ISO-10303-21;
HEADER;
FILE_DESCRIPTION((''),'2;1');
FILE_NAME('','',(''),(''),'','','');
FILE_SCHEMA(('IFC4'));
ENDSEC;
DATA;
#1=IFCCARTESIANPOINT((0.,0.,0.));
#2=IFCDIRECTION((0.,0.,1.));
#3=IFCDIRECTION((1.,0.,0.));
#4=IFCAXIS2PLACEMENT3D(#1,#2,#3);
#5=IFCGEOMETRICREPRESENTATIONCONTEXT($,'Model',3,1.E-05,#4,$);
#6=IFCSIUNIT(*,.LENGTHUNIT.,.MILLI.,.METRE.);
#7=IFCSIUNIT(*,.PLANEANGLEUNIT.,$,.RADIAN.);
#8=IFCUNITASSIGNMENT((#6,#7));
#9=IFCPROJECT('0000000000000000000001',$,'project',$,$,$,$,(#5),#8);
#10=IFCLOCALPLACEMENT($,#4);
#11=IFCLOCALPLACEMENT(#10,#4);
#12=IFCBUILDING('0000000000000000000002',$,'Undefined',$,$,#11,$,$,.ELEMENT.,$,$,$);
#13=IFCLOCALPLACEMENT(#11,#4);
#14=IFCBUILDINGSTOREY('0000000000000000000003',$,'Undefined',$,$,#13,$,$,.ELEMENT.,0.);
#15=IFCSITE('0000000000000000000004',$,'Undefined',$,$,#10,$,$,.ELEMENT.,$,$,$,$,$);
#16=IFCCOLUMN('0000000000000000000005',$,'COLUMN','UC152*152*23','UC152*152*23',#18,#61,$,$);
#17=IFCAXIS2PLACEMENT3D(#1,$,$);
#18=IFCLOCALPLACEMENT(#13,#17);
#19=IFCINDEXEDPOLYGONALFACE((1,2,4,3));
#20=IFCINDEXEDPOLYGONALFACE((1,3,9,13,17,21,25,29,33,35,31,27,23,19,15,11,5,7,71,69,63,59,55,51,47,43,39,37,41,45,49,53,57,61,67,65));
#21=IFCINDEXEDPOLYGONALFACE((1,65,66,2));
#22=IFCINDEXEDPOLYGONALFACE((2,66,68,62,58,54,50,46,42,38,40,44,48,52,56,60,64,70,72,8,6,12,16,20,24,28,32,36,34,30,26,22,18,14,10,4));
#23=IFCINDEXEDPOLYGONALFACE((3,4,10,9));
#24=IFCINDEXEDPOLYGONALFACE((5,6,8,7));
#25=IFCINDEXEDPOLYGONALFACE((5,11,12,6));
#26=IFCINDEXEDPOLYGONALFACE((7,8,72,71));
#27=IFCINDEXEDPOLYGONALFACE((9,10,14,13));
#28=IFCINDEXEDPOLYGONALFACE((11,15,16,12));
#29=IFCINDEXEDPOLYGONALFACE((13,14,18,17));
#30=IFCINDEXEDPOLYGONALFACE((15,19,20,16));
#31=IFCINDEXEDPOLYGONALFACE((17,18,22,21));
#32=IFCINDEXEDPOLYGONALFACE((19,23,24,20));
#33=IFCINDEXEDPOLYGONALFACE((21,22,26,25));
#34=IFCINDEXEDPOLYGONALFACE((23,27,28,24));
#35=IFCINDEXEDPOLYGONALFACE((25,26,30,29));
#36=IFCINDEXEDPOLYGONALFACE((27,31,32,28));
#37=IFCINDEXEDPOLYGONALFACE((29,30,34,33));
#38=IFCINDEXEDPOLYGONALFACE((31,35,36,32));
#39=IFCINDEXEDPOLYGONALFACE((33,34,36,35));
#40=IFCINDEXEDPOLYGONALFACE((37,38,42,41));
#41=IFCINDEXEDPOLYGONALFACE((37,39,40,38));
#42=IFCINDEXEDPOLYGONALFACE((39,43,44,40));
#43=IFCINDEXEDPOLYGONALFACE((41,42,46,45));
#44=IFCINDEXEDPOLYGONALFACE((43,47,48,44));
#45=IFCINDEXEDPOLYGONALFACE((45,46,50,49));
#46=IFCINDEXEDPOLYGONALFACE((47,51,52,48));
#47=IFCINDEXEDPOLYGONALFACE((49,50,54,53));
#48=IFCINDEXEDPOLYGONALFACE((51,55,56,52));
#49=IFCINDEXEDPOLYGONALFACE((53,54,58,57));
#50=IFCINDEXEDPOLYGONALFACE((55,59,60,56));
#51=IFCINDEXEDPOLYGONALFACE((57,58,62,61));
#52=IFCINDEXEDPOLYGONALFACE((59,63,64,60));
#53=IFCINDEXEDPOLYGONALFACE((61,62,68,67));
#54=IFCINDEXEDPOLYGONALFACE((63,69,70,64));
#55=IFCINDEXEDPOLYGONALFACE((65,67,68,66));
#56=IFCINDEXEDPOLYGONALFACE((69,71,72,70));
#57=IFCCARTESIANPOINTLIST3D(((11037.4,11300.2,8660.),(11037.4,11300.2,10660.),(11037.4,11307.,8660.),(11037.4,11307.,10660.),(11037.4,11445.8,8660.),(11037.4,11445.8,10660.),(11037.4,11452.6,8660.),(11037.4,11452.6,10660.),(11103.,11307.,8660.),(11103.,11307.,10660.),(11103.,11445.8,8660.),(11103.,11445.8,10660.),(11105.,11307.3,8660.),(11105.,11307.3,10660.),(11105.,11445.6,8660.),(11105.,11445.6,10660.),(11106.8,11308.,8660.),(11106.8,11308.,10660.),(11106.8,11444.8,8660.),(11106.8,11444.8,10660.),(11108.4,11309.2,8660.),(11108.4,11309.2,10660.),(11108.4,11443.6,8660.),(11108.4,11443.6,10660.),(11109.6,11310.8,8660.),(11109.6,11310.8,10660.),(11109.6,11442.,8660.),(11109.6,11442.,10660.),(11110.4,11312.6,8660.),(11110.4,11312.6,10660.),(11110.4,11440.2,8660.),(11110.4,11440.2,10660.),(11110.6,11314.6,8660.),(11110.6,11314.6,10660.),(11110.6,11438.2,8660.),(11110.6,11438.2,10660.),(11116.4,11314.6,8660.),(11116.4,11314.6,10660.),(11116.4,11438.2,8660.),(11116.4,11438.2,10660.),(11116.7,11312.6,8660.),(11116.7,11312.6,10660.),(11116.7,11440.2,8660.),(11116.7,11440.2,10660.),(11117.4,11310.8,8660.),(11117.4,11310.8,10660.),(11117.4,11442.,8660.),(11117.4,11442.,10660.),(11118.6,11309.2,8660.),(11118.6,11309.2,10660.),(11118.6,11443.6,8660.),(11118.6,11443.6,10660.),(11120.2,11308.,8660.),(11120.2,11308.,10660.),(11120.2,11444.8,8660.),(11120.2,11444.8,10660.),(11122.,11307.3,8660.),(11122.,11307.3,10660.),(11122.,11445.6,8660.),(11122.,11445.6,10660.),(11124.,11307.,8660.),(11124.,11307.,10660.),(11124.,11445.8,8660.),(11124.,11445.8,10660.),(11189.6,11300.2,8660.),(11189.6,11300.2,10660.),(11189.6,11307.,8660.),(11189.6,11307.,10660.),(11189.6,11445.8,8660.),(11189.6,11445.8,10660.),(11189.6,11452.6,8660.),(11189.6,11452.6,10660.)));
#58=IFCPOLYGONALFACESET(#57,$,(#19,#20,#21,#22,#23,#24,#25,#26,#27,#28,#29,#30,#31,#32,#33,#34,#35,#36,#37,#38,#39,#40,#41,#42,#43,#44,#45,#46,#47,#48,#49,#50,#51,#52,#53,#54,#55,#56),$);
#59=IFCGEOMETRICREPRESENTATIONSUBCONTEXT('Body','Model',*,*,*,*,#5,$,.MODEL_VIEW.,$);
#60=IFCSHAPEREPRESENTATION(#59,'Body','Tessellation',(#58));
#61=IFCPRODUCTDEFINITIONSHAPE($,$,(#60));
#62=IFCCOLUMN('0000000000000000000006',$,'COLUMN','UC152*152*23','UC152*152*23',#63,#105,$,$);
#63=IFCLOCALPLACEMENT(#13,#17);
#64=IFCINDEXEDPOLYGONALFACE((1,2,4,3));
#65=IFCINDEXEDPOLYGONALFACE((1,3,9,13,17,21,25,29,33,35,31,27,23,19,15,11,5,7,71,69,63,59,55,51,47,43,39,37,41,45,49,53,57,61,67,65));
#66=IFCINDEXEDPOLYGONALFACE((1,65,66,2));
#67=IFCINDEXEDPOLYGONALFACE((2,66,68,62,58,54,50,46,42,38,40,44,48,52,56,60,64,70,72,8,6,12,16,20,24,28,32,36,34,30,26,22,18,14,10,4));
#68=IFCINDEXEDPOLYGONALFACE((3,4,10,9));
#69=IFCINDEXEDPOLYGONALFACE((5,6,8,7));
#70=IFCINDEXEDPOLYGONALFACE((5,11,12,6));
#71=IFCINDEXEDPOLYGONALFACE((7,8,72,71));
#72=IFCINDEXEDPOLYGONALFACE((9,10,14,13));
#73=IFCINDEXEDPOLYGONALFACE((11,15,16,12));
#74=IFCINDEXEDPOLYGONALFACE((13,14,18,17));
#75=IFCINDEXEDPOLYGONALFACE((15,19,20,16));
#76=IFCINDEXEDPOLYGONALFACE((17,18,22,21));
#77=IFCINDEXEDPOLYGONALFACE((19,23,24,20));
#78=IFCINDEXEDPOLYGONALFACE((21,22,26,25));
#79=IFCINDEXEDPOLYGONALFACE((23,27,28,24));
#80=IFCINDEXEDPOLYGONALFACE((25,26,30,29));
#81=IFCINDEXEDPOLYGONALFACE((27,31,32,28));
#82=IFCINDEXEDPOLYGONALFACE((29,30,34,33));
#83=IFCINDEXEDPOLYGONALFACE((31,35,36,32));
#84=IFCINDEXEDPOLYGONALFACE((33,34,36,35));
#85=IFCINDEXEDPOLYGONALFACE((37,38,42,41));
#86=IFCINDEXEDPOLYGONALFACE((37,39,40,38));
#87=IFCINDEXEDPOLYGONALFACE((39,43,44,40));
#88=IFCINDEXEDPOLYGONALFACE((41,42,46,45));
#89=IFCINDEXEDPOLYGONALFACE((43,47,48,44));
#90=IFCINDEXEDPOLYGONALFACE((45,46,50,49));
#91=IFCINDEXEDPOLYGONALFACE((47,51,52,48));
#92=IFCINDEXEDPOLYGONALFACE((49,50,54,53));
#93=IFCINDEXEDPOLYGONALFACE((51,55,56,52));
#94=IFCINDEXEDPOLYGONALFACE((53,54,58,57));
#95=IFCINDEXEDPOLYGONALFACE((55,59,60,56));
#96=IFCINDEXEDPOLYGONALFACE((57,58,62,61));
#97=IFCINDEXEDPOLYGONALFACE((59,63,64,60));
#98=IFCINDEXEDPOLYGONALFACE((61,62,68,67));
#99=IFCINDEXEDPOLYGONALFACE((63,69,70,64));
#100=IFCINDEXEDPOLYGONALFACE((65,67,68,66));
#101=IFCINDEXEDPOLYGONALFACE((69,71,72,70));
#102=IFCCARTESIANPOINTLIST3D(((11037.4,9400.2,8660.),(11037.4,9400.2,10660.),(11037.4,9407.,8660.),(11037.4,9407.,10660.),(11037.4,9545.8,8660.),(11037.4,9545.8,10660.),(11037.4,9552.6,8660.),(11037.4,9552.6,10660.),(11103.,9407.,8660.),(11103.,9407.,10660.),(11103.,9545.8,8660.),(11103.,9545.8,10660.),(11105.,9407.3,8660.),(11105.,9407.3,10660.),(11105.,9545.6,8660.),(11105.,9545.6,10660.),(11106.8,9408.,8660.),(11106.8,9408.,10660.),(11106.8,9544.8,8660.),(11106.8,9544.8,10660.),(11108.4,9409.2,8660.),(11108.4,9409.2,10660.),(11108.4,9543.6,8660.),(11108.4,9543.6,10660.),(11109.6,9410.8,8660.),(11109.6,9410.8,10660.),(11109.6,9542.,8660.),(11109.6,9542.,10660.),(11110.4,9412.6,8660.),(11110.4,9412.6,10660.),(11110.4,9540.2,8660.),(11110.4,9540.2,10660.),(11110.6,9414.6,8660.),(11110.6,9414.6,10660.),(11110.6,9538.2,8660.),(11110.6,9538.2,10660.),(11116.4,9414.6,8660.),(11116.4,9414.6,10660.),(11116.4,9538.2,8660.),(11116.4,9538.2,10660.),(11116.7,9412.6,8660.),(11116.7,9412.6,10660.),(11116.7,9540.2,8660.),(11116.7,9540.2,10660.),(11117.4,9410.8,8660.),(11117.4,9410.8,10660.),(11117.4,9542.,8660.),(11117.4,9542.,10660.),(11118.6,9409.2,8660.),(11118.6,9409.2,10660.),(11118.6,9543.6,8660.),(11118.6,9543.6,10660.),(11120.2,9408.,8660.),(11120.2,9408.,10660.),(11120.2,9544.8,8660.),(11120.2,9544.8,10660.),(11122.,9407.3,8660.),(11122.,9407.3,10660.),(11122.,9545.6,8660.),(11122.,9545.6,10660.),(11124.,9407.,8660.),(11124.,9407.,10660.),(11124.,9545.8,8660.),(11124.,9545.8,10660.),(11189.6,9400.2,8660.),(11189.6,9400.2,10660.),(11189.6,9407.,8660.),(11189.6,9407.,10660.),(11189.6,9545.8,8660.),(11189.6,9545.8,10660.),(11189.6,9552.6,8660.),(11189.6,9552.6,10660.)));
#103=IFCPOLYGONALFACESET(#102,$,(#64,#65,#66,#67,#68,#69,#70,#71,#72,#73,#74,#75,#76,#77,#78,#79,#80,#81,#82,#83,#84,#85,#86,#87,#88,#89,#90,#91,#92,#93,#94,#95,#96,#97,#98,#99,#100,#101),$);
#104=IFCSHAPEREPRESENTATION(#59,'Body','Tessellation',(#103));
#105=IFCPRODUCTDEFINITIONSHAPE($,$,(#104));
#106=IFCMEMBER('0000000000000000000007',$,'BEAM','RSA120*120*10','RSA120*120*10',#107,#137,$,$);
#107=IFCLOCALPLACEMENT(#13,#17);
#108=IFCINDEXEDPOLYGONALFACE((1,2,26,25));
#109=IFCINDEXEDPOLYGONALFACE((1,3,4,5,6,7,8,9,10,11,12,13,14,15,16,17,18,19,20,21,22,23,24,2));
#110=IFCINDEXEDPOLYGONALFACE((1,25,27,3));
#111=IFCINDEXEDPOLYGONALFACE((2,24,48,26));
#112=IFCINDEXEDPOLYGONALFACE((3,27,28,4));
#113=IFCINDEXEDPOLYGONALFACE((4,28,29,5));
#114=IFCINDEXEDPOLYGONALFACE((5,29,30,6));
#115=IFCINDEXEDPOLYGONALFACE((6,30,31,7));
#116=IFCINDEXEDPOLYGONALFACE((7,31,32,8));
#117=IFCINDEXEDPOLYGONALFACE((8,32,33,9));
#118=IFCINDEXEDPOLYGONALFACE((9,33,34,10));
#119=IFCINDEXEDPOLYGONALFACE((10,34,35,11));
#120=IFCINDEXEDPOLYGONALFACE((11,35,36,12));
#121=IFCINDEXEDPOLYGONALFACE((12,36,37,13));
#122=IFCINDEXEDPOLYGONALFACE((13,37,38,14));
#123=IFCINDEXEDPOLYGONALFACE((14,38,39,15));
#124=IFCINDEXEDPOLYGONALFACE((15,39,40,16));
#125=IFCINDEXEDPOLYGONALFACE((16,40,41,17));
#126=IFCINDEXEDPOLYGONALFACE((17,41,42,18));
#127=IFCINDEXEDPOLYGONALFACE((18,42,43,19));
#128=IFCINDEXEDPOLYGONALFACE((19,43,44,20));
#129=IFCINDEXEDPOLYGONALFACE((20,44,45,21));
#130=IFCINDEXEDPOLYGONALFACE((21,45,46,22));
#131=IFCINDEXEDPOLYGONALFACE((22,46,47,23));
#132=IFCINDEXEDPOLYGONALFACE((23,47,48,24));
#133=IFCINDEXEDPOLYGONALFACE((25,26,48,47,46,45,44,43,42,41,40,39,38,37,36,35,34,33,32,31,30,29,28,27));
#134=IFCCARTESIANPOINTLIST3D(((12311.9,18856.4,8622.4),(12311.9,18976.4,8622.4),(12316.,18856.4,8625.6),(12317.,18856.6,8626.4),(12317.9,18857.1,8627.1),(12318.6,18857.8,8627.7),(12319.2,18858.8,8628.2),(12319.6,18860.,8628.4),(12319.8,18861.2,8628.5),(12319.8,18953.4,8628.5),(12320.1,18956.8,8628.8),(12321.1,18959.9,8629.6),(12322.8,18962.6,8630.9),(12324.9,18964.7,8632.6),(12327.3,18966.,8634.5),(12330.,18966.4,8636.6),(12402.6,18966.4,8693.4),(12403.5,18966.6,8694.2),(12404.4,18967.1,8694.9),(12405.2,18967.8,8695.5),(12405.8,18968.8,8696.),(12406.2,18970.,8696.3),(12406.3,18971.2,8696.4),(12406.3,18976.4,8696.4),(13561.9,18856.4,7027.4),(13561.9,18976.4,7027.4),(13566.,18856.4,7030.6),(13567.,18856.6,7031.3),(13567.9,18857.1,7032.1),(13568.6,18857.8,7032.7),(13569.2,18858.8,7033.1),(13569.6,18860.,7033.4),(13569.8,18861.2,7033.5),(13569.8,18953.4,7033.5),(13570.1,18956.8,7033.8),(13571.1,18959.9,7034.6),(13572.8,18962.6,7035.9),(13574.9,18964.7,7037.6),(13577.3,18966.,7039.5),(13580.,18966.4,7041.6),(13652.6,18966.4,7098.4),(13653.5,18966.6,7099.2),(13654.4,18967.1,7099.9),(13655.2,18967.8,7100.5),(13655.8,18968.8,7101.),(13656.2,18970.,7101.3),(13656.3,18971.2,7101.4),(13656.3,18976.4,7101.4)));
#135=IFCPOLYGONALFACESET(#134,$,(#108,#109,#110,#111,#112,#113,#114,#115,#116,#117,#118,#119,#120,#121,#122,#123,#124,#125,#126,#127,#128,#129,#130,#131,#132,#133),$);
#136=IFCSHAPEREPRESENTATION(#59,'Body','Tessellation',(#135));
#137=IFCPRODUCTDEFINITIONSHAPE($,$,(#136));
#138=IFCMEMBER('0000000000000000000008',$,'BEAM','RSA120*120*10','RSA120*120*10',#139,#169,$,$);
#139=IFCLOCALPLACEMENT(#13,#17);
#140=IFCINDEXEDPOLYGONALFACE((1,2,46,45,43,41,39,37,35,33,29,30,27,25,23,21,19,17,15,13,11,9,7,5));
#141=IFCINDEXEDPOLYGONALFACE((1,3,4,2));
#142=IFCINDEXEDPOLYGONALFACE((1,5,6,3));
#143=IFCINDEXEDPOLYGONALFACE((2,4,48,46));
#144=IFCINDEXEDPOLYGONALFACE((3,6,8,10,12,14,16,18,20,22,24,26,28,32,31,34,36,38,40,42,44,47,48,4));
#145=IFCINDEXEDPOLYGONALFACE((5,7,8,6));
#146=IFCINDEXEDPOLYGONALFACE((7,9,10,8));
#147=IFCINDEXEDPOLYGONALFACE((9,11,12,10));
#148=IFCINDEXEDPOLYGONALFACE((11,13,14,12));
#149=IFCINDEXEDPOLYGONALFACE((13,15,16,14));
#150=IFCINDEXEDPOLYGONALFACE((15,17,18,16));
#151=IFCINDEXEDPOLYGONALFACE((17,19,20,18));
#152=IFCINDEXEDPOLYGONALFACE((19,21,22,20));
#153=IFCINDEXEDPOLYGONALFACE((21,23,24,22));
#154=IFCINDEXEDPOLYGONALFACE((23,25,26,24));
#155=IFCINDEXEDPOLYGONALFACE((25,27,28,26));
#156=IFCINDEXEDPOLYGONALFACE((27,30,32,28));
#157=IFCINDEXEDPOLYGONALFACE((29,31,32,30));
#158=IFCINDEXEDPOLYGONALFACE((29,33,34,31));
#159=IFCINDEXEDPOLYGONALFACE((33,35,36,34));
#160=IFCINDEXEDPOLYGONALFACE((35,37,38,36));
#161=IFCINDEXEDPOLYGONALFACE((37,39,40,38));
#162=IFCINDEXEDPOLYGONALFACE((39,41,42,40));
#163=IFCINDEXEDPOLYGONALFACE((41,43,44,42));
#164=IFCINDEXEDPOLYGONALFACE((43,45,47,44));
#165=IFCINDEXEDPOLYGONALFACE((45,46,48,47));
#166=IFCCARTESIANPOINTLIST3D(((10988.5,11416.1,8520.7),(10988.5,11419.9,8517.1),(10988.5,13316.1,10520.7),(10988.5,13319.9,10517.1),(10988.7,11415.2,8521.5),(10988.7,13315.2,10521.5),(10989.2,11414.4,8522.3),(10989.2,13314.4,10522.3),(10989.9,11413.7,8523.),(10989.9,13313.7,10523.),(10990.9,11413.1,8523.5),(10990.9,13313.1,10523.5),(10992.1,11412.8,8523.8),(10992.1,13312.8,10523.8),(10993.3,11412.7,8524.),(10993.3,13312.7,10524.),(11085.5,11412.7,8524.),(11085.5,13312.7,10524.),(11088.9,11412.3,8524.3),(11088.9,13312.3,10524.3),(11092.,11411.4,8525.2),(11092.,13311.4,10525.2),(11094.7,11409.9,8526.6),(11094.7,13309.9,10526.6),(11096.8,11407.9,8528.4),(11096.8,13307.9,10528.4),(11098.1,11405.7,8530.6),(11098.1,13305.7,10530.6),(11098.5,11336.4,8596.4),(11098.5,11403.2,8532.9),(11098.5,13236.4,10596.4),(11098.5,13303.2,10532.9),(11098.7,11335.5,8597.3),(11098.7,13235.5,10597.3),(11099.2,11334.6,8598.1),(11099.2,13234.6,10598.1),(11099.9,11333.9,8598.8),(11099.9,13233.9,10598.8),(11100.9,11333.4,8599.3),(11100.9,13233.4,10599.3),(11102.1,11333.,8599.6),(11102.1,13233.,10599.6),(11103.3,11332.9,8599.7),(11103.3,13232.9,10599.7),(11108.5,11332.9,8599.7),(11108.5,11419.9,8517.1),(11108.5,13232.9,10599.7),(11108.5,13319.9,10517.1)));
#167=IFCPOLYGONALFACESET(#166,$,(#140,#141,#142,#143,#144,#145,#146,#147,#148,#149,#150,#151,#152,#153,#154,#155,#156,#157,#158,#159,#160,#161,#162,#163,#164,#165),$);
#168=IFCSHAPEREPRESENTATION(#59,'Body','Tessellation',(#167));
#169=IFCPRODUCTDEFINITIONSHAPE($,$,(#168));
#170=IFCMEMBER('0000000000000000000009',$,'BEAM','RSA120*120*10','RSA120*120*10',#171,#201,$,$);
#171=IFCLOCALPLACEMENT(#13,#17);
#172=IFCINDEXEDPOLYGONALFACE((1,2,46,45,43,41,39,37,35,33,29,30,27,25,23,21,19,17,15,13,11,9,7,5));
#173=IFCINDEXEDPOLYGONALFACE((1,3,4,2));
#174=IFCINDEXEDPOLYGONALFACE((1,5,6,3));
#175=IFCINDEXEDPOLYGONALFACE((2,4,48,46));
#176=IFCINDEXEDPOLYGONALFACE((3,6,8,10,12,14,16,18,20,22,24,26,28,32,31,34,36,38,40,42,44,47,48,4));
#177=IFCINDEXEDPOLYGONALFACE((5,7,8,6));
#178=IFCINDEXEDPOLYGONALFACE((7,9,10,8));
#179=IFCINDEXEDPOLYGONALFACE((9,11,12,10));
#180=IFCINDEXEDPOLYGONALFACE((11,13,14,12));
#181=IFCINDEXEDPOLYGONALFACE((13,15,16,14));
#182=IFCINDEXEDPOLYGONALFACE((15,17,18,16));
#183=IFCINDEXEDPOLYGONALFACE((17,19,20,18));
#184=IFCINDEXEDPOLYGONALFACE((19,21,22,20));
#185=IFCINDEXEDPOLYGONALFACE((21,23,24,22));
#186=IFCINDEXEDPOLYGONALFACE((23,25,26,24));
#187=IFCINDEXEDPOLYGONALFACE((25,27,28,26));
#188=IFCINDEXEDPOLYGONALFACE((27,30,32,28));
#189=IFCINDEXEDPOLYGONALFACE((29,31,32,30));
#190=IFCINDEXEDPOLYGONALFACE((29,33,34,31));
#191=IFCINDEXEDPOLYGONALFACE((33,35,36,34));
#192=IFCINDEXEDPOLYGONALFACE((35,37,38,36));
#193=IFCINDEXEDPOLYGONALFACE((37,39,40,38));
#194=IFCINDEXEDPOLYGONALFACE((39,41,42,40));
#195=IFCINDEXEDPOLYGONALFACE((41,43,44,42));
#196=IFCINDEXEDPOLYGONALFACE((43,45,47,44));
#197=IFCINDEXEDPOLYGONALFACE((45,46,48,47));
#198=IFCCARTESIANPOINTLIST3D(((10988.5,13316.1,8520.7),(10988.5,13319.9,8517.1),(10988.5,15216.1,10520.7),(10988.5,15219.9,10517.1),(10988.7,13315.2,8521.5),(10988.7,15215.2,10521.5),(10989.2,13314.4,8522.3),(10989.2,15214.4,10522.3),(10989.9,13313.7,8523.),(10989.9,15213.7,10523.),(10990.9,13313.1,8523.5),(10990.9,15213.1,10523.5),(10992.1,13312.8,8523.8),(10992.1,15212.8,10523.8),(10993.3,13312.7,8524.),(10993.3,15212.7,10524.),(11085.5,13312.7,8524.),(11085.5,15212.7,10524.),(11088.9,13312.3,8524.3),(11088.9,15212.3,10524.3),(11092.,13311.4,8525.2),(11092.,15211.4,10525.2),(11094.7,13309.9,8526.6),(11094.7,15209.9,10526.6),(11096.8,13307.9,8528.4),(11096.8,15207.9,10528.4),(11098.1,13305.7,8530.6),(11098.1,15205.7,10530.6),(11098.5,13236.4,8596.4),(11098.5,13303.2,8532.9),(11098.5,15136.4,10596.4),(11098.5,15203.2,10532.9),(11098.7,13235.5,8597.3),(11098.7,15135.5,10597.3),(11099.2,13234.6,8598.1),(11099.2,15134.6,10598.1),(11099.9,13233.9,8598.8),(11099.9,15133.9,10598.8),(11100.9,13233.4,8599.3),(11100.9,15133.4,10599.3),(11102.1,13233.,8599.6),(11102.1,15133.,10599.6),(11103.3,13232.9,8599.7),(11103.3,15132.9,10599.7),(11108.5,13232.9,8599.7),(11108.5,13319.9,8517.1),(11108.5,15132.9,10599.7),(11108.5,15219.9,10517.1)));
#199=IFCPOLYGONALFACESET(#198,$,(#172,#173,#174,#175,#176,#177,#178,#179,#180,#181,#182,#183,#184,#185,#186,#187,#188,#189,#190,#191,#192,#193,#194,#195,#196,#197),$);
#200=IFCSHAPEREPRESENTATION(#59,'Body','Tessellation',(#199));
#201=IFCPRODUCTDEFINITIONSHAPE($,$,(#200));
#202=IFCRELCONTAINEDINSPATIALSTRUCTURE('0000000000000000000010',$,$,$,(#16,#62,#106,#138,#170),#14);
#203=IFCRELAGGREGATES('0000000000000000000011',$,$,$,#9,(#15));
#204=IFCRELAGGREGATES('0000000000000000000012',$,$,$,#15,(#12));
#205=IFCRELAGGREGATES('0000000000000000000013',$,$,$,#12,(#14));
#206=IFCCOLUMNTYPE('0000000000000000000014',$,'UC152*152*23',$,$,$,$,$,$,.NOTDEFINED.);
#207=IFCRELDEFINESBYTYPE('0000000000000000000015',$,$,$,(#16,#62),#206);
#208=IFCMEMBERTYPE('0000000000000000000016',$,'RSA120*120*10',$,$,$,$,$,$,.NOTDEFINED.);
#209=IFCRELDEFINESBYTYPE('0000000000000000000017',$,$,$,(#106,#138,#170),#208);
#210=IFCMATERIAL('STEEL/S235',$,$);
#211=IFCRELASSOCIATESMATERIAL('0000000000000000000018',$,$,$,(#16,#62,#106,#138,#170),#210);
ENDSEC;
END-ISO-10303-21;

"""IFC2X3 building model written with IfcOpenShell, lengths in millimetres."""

from ifc_helpers import new_model, si_unit, frame, origin_with_axes, origin_2d_with_axis, place, context, subcontext, project, spatial, i_section, l_section, extrude, material, type_object, element, save


model = new_model("IFC2X3")

# Units and contexts
model_context = context("Model", 3, precision=1e-05, world=origin_with_axes())
body_context = subcontext(model_context, "Body", "Model", "MODEL_VIEW")
ifc_project = project(units=[si_unit("LENGTHUNIT", "METRE", prefix="MILLI"), si_unit("PLANEANGLEUNIT", "RADIAN")], contexts=[model_context])

# Site, building, storey
site_placement = place(None, origin_with_axes())
site = spatial("IfcSite", under=ifc_project, at=site_placement, Name="Undefined", CompositionType="ELEMENT")
building_placement = place(site_placement, origin_with_axes())
building = spatial("IfcBuilding", under=site, at=building_placement, Name="Undefined", CompositionType="ELEMENT")
storey_placement = place(building_placement, origin_with_axes())
storey = spatial("IfcBuildingStorey", under=building, at=storey_placement, Name="Undefined", CompositionType="ELEMENT", Elevation=0.0)

# Columns
ifc_material = material(Name="STEEL/S235")
column_type = type_object("IfcColumnType", Name="UC152*152*23", PredefinedType="NOTDEFINED")
for number, where, z_axis, x_axis, name in (
    (1, (11113.5, 11376.4, 8660.0), (0.0, 0.0, 1.0), (0.0, -1.0, 0.0), "COLUMN"),
    (2, (11113.5, 9476.4, 8660.0), (0.0, 0.0, 1.0), (0.0, -1.0, 0.0), "COLUMN"),
):
    element("IfcColumn", number, at=place(storey_placement, frame(where, z_axis=z_axis, x_axis=x_axis)), inside=storey, type_object=column_type, material=ifc_material, Name=name, Description="UC152*152*23", ObjectType="UC152*152*23", context=body_context, shape_type="SweptSolid", body=[
        extrude(i_section(OverallWidth=152.2, OverallDepth=152.4, WebThickness=5.8, FlangeThickness=6.8, FilletRadius=7.6, at=origin_2d_with_axis()), frame((0.0, 0.0, 2000.0), z_axis=(0.0, 0.0, -1.0), x_axis=(0.0, 1.0, 0.0)), (0.0, 0.0, 1.0), 2000.0),
    ])

# Members
member_type = type_object("IfcMemberType", Name="RSA120*120*10", PredefinedType="NOTDEFINED")
member_placement = place(storey_placement, frame((12359.1, 18916.4, 8659.4), z_axis=(0.787088, 0.0, 0.61684), x_axis=(0.61684, 0.0, -0.787088)))
element("IfcMember", 3, at=member_placement, inside=storey, type_object=member_type, material=ifc_material, Name="BEAM", Description="RSA120*120*10", ObjectType="RSA120*120*10", context=body_context, shape_type="SweptSolid", body=[
    extrude(l_section(Depth=120.0, Width=120.0, Thickness=10.0, FilletRadius=13.0, EdgeRadius=4.8, at=origin_2d_with_axis()), frame((2026.5, 0.0, 0.0), z_axis=(-1.0, 0.0, 0.0), x_axis=(0.0, -1.0, 0.0)), (0.0, 0.0, 1.0), 2026.5),
])
for number, where, z_axis, x_axis, name in (
    (4, (11048.5, 13276.4, 10558.4), (0.0, -0.724999, 0.688749), (0.0, -0.688749, -0.724999), "BEAM"),
    (5, (11048.5, 15176.4, 10558.4), (0.0, -0.724999, 0.688749), (0.0, -0.688749, -0.724999), "BEAM"),
):
    element("IfcMember", number, at=place(storey_placement, frame(where, z_axis=z_axis, x_axis=x_axis)), inside=storey, type_object=member_type, material=ifc_material, Name=name, Description="RSA120*120*10", ObjectType="RSA120*120*10", context=body_context, shape_type="SweptSolid", body=[
        extrude(l_section(Depth=120.0, Width=120.0, Thickness=10.0, FilletRadius=13.0, EdgeRadius=4.8, at=origin_2d_with_axis()), frame((2758.6, 0.0, 0.0), z_axis=(-1.0, 0.0, 0.0), x_axis=(0.0, -1.0, 0.0)), (0.0, 0.0, 1.0), 2758.6),
    ])

save(model, "model.ifc")
